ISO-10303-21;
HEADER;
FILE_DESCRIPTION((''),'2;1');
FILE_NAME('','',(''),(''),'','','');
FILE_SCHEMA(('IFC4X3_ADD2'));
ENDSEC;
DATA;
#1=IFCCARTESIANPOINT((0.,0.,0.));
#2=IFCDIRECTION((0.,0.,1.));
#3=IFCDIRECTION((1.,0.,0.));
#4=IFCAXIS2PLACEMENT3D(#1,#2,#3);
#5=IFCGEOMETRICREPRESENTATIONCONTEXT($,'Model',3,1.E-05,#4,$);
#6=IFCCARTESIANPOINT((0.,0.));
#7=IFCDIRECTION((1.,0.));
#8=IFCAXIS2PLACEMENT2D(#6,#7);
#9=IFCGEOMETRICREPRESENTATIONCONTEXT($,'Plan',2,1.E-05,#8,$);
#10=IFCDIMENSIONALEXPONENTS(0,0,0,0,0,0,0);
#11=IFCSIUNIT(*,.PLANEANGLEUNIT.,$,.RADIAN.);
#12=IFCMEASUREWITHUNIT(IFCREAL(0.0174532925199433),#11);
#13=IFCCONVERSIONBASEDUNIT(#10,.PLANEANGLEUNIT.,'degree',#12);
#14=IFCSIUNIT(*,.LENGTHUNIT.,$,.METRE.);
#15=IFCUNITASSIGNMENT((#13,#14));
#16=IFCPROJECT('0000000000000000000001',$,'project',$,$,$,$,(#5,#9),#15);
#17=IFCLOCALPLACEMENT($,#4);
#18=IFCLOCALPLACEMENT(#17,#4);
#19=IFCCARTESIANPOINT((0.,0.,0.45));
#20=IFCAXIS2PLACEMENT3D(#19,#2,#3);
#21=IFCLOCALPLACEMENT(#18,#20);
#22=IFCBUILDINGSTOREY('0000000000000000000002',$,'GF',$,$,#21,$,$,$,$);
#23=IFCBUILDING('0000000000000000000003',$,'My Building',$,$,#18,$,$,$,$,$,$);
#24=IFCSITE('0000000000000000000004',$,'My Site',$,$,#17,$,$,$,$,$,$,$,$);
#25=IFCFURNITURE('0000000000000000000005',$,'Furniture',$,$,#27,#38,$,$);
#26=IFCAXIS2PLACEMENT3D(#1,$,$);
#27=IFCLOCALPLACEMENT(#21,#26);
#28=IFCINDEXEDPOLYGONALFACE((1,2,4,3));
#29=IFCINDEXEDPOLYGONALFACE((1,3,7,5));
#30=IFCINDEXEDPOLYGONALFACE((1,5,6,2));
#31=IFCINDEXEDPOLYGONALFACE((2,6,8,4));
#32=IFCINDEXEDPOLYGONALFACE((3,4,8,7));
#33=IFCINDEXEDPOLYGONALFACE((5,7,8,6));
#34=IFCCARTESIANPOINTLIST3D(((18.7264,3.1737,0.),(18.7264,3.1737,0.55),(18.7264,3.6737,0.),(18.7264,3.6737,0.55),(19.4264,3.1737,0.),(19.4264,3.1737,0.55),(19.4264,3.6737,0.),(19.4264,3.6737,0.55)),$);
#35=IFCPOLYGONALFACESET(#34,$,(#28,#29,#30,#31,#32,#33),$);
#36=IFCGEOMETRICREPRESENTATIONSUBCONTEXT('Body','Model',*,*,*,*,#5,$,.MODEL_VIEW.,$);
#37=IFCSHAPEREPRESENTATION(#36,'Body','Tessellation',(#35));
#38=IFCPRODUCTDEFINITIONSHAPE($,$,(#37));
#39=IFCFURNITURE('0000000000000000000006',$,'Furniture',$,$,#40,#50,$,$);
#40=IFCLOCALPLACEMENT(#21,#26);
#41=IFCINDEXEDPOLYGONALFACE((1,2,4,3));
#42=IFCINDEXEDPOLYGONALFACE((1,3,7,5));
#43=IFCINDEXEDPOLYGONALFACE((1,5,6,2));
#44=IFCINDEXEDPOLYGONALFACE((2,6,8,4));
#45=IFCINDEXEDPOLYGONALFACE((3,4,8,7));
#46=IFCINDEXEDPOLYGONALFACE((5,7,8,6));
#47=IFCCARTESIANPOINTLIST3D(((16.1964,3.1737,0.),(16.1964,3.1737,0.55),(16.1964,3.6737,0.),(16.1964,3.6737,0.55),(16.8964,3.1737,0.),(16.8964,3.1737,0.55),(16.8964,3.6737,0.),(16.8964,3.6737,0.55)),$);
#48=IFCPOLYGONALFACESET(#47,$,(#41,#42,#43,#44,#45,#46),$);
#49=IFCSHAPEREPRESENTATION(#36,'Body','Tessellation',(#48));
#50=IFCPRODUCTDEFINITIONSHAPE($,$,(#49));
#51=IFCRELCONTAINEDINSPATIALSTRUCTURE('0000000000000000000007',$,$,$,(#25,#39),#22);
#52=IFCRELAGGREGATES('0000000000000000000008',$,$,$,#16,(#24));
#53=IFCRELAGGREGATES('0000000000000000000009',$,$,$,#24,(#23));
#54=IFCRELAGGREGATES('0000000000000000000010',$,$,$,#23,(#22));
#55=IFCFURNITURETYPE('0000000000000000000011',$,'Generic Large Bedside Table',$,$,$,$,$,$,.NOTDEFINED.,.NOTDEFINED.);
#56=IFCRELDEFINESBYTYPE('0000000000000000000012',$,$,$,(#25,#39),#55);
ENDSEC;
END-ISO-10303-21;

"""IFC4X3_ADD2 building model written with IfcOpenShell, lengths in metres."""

from ifc_helpers import new_model, entity, si_unit, converted_unit, frame, origin_with_axes, origin_2d_with_axis, place, context, subcontext, project, spatial, line, indexed_curve, outline, extrude, shape, source, transform, mapped, type_object, type_shapes, element, save


model = new_model("IFC4X3_ADD2")

# Units and contexts
model_context = context("Model", 3, precision=1e-05, world=origin_with_axes())
plan_context = context("Plan", 2, precision=1e-05, world=origin_2d_with_axis())
body_context_1 = subcontext(model_context, "Body", "Model", "MODEL_VIEW")
body_context_2 = subcontext(plan_context, "Body", "Plan", "PLAN_VIEW")
ifc_project = project(units=[converted_unit("PLANEANGLEUNIT", "degree", entity("IfcReal", 0.0174532925199433), si_unit("PLANEANGLEUNIT", "RADIAN"), dimensions=[0, 0, 0, 0, 0, 0, 0]), si_unit("LENGTHUNIT", "METRE")], contexts=[model_context, plan_context])

# Site, building, storey
site_placement = place(None, origin_with_axes())
site = spatial("IfcSite", under=ifc_project, at=site_placement, Name="My Site")
building_placement = place(site_placement, origin_with_axes())
building = spatial("IfcBuilding", under=site, at=building_placement, Name="My Building")
storey_placement = place(building_placement, frame((0.0, 0.0, 0.45), z_axis=(0.0, 0.0, 1.0), x_axis=(1.0, 0.0, 0.0)))
storey = spatial("IfcBuildingStorey", under=building, at=storey_placement, Name="GF")

# Furniture
furniture_type_1 = type_object("IfcFurnitureType", Name="Generic Large Bedside Table", AssemblyPlace="NOTDEFINED", PredefinedType="NOTDEFINED")
shared_shape_1 = source(origin_with_axes(), body_context_1, "Body", "SweptSolid", [
    extrude(outline(indexed_curve([(0.0, 0.0), (0.7, 0.0), (0.7, 0.5), (0.0, 0.5)], segments=[line(1, 2, 3, 4, 1)])), frame((-0.35, -0.25, 0.0), z_axis=(0.0, 0.0, 1.0), x_axis=(1.0, 0.0, 0.0)), (0.0, 0.0, 1.0), 0.55),
])
shared_shape_2 = source(origin_with_axes(), body_context_2, "Body", "Curve2D", [
    entity("IfcIndexedPolyCurve", entity("IfcCartesianPointList2D", [[-0.35, -0.25], [0.35, -0.25], [0.35, 0.25], [-0.35, 0.25]]), [entity("IfcLineIndex", [1, 2, 3, 4, 1])]),
])
type_shapes(furniture_type_1, [shared_shape_1, shared_shape_2])
for number, where, z_axis, x_axis, name in (
    (1, (19.0764, 3.4237, 0.0), (0.0, 0.0, 1.0), (1.0, 0.0, 0.0), "Furniture"),
    (2, (16.5464, 3.4237, 0.0), (0.0, 0.0, 1.0), (1.0, 0.0, 0.0), "Furniture"),
):
    element("IfcFurniture", number, at=place(storey_placement, frame(where, z_axis=z_axis, x_axis=x_axis)), inside=storey, type_object=furniture_type_1, Name=name, shapes=[
        shape(body_context_1, "Body", "MappedRepresentation", [mapped(shared_shape_1, transform((0.0, 0.0, 0.0), x_axis=(1.0, 0.0, 0.0), y_axis=(0.0, 1.0, 0.0), z_axis=(0.0, 0.0, 1.0), scale=1.0))]),
        shape(body_context_2, "Body", "MappedRepresentation", [mapped(shared_shape_2, transform((0.0, 0.0, 0.0), x_axis=(1.0, 0.0, 0.0), y_axis=(0.0, 1.0, 0.0), z_axis=(0.0, 0.0, 1.0), scale=1.0))]),
    ])

save(model, "model.ifc")
